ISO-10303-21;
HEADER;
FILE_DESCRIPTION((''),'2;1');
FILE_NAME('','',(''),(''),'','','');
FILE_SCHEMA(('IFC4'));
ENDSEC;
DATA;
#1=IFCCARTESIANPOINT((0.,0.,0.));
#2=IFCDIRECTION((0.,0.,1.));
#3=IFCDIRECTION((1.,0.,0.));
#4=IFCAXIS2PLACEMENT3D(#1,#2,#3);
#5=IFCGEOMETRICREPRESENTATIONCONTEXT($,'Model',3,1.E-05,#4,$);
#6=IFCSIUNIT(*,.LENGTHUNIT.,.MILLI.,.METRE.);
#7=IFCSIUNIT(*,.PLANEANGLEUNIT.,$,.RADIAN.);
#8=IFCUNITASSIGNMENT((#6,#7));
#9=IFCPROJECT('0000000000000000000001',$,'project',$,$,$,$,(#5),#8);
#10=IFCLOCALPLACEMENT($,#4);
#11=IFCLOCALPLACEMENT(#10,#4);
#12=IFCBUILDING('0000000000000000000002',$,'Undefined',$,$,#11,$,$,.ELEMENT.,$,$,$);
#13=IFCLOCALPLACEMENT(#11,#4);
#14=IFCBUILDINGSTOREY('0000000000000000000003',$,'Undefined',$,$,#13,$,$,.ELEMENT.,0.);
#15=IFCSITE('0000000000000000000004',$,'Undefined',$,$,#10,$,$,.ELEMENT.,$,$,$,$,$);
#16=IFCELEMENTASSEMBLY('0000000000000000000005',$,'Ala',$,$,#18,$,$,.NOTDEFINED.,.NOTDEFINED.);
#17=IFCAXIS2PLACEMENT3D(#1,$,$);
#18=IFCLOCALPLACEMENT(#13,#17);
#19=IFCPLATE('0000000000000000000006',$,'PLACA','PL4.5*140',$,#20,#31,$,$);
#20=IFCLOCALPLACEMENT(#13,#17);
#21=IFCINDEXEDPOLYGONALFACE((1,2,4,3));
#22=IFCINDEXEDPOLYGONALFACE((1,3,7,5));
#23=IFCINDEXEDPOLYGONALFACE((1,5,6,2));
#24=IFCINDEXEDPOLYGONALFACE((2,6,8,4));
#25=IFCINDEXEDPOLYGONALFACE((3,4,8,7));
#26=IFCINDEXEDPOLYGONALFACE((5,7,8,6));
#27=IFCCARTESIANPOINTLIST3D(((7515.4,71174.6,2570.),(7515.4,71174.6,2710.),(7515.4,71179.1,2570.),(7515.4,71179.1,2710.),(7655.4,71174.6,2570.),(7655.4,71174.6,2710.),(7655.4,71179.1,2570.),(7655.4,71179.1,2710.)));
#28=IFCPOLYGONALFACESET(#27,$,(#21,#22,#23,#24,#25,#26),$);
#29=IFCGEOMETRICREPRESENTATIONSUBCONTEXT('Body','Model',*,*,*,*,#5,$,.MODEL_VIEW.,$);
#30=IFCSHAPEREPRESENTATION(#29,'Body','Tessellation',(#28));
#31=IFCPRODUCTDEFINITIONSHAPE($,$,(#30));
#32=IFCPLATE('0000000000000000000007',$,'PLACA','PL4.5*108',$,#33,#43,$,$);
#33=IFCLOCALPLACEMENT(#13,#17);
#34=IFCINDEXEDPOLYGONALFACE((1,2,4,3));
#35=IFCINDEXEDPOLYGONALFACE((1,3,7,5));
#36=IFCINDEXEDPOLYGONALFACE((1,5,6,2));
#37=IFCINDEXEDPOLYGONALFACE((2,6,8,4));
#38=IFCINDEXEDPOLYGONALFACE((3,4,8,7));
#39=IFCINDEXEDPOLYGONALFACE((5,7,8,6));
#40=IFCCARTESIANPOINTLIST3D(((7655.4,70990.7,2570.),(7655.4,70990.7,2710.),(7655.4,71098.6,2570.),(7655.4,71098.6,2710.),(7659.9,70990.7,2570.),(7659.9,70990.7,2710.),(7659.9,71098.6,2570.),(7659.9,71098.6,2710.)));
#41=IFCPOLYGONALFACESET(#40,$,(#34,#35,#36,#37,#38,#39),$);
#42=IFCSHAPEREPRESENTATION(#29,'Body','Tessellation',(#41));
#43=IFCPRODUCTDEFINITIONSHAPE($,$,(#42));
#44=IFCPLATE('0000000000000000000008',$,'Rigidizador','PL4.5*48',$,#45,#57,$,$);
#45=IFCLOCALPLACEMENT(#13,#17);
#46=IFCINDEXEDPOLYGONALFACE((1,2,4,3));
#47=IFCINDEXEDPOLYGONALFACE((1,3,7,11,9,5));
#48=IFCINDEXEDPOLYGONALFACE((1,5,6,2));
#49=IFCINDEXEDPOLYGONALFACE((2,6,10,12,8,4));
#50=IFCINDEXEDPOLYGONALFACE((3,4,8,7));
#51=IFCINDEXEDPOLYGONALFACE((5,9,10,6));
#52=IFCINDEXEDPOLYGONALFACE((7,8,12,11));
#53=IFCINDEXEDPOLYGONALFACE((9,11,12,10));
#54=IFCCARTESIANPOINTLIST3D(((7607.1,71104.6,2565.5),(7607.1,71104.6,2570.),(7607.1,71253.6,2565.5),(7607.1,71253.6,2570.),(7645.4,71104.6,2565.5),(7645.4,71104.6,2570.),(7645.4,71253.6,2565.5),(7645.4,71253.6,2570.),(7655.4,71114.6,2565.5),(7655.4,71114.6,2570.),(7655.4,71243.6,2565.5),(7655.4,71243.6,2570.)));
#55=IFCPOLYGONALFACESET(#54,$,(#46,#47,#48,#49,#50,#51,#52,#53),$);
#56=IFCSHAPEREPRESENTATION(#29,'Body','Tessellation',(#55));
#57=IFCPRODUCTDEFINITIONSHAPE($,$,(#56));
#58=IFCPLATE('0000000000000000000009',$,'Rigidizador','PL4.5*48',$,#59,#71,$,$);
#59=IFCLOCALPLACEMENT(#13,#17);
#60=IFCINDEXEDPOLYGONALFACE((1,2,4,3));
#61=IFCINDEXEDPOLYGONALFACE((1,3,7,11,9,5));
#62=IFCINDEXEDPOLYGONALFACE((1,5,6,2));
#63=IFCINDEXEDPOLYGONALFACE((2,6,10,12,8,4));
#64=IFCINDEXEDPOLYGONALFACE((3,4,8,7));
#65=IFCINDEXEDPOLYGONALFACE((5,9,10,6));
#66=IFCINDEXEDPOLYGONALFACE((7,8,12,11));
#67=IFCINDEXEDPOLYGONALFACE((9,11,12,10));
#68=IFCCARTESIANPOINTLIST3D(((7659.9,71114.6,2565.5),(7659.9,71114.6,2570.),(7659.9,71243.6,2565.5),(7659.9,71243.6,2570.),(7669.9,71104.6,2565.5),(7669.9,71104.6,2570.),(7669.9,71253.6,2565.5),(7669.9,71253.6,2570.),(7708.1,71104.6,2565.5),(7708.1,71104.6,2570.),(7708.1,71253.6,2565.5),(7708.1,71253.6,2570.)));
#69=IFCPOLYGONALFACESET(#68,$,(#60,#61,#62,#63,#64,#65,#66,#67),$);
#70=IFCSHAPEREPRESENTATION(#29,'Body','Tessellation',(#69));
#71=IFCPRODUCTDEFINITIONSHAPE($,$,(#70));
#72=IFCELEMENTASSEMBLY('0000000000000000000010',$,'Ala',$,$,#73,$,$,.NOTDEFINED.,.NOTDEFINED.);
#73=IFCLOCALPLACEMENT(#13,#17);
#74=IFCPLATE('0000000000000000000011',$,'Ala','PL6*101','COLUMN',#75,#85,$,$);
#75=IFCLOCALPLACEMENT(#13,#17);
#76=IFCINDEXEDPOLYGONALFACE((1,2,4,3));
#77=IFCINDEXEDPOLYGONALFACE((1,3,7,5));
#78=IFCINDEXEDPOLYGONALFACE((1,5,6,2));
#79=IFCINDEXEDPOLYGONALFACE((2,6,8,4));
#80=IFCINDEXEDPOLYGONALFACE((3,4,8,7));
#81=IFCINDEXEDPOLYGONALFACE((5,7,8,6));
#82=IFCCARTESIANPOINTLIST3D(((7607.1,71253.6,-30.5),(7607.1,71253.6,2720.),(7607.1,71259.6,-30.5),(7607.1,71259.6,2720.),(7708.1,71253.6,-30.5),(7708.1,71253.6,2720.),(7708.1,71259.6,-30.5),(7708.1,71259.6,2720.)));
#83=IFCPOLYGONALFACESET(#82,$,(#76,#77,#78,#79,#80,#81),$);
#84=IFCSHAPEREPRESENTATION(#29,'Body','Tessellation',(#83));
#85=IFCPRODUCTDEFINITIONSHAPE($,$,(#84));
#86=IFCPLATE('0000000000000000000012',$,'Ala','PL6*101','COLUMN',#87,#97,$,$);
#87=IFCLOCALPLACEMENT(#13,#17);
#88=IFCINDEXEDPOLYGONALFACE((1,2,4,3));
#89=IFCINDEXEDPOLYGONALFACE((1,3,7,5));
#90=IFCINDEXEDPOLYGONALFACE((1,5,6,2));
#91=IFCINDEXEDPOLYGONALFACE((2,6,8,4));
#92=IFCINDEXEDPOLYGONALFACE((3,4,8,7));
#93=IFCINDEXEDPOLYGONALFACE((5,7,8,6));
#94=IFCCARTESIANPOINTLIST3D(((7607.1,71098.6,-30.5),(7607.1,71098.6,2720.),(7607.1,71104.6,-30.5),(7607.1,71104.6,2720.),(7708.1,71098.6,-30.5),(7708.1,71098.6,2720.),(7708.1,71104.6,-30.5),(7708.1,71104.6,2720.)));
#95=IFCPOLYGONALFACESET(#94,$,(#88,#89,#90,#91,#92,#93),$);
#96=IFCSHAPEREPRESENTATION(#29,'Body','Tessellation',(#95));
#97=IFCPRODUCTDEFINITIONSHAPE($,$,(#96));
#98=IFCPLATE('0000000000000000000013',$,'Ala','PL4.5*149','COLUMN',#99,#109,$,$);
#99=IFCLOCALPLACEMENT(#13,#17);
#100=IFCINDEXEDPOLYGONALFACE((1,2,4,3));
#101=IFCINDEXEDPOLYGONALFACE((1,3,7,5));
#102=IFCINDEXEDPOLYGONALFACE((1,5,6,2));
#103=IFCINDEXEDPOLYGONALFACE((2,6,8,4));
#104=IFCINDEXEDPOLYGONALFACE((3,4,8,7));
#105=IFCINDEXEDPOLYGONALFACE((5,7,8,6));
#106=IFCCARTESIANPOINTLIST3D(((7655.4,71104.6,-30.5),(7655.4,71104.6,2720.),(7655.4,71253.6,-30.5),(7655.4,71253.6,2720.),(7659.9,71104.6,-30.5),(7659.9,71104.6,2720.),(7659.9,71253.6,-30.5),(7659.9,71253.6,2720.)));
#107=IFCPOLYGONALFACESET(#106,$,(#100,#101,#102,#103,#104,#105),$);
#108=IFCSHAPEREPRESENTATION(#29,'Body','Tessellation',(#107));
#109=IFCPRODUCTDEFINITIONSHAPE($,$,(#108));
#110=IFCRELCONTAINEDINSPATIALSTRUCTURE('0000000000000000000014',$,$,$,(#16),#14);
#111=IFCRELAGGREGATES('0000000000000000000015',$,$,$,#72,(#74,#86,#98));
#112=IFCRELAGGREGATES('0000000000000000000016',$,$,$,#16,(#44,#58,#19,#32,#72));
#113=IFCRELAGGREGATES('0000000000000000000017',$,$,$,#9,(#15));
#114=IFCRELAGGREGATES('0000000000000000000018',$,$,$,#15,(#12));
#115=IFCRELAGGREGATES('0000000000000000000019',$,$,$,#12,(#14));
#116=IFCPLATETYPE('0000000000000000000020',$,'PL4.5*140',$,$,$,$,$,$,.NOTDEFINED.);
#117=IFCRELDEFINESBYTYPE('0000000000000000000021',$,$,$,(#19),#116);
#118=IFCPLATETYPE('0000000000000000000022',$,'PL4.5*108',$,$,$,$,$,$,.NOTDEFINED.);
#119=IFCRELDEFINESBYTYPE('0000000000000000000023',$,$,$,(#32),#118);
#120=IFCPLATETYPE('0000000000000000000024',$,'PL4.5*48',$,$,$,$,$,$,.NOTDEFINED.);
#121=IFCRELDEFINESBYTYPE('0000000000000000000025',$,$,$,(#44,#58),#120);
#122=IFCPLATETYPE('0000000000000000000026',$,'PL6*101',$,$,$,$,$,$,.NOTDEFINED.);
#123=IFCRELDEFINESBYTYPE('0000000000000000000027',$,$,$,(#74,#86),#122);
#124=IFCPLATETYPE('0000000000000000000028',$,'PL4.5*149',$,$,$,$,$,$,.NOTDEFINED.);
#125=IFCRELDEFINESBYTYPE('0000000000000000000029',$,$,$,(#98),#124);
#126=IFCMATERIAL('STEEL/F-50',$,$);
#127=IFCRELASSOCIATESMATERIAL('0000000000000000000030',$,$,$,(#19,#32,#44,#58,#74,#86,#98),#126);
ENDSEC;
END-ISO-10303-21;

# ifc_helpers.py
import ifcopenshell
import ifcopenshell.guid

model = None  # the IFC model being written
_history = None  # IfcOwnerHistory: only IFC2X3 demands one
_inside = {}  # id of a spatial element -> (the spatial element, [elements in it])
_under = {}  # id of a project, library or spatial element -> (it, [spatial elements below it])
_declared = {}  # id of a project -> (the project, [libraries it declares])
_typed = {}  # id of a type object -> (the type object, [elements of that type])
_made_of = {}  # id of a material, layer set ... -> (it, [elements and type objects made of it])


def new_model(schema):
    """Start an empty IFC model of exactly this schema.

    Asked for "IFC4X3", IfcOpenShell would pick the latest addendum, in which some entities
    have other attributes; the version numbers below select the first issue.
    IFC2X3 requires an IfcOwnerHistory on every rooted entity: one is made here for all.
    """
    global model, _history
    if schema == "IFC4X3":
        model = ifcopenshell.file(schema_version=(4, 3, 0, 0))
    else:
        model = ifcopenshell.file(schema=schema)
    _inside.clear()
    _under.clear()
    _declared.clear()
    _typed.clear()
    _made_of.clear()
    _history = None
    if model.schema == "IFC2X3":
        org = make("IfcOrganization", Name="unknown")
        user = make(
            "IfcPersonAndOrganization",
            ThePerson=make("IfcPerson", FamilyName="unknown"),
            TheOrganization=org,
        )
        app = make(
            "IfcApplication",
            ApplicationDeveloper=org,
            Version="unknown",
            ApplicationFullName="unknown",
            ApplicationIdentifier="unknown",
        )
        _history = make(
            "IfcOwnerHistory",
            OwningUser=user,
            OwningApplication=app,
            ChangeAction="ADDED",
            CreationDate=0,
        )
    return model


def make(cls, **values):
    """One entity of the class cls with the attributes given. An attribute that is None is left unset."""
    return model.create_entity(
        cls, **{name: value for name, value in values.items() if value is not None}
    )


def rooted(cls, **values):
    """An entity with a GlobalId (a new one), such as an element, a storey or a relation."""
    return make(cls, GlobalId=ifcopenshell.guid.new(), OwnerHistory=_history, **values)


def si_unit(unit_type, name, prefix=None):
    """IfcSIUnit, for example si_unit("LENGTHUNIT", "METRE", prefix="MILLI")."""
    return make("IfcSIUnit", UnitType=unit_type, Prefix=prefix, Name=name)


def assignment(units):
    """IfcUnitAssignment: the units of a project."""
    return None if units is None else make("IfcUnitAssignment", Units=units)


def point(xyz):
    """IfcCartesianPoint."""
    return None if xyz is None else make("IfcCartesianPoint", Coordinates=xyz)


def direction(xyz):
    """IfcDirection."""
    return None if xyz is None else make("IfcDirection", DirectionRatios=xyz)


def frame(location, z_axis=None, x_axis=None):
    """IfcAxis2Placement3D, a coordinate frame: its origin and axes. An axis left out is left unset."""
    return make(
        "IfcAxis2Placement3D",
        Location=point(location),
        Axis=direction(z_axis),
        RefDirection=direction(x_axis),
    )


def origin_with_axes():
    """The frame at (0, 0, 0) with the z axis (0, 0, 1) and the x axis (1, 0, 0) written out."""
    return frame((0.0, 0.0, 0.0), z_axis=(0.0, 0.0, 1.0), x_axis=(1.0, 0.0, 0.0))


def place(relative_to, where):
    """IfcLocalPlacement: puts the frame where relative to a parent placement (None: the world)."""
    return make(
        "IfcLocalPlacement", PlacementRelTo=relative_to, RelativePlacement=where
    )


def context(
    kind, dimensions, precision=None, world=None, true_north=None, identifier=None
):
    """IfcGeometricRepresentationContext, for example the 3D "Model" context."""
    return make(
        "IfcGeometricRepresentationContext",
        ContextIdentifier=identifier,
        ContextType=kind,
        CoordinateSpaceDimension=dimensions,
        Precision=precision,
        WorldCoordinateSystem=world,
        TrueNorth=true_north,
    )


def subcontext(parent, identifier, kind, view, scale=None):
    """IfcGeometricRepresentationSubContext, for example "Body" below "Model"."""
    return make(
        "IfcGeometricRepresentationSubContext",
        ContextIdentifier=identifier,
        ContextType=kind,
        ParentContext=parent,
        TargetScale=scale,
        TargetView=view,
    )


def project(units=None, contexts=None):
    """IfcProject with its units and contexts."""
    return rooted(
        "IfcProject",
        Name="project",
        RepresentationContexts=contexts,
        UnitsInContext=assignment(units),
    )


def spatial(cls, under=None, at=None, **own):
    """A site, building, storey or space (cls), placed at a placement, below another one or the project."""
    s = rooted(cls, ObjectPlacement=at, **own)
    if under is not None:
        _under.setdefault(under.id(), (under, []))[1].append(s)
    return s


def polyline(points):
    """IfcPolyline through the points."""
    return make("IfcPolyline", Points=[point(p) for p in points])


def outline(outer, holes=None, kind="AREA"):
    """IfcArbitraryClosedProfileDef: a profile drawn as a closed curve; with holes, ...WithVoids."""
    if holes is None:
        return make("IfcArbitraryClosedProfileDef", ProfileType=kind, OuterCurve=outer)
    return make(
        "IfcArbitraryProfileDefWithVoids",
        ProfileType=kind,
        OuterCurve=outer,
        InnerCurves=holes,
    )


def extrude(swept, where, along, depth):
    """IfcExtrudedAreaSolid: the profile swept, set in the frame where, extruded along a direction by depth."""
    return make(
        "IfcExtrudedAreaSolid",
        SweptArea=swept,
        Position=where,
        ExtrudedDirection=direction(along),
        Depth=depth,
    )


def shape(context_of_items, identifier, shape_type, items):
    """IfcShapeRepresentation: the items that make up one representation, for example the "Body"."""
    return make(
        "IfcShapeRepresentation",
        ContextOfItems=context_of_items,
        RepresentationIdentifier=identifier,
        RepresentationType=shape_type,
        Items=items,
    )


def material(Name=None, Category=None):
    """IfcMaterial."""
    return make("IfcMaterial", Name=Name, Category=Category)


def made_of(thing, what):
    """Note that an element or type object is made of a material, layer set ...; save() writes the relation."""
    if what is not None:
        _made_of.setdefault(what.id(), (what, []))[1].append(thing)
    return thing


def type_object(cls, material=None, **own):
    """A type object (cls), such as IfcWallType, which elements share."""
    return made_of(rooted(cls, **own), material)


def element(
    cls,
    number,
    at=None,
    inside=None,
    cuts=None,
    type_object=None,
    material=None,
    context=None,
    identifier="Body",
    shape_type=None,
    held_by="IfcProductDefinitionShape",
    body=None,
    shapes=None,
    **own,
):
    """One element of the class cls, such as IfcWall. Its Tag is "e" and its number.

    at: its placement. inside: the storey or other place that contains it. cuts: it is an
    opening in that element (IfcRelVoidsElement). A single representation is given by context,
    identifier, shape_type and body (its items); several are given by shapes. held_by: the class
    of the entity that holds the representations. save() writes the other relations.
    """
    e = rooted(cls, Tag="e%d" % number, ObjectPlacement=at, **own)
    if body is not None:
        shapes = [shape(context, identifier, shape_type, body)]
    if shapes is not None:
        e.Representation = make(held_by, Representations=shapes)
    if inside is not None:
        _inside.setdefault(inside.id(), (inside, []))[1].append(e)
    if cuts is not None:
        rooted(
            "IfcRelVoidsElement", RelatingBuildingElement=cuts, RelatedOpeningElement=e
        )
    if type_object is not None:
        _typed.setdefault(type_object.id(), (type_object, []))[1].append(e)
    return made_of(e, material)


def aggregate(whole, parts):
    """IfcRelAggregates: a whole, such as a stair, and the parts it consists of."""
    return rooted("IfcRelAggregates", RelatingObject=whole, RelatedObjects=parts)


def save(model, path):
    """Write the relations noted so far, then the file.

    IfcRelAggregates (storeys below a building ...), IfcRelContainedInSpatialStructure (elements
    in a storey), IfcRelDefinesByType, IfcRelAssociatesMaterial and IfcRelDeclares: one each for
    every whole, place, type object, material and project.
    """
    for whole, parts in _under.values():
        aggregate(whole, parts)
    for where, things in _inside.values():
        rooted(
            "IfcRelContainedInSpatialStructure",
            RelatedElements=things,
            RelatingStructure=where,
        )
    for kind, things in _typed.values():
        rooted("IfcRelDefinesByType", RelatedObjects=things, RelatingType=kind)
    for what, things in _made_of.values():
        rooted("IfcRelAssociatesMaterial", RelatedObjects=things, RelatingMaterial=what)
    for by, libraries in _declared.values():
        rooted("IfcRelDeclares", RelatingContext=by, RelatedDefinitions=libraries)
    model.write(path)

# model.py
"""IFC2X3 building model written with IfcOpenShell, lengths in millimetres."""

from ifc_helpers import new_model, si_unit, frame, origin_with_axes, place, context, subcontext, project, spatial, polyline, outline, extrude, material, type_object, element, aggregate, save


model = new_model("IFC2X3")

# Units and contexts
model_context = context("Model", 3, precision=1e-05, world=origin_with_axes())
body_context = subcontext(model_context, "Body", "Model", "MODEL_VIEW")
ifc_project = project(units=[si_unit("LENGTHUNIT", "METRE", prefix="MILLI"), si_unit("PLANEANGLEUNIT", "RADIAN")], contexts=[model_context])

# Site, building, storey
site_placement = place(None, origin_with_axes())
site = spatial("IfcSite", under=ifc_project, at=site_placement, Name="Undefined", CompositionType="ELEMENT")
building_placement = place(site_placement, origin_with_axes())
building = spatial("IfcBuilding", under=site, at=building_placement, Name="Undefined", CompositionType="ELEMENT")
storey_placement = place(building_placement, origin_with_axes())
storey = spatial("IfcBuildingStorey", under=building, at=storey_placement, Name="Undefined", CompositionType="ELEMENT", Elevation=0.0)

# Element assembly
assembly_1_placement = place(storey_placement, origin_with_axes())
assembly_1 = element("IfcElementAssembly", 1, at=assembly_1_placement, inside=storey, Name="Ala", AssemblyPlace="NOTDEFINED", PredefinedType="NOTDEFINED")

# Plates
ifc_material_1 = material(Name="STEEL/F-50")
plate_type_1 = type_object("IfcPlateType", Name="PL4.5*140", PredefinedType="NOTDEFINED")
plate_1_placement = place(assembly_1_placement, frame((7655.4, 71176.8, 2570.0), z_axis=(0.0, -1.0, 0.0), x_axis=(0.0, 0.0, 1.0)))
plate_1 = element("IfcPlate", 2, at=plate_1_placement, type_object=plate_type_1, material=ifc_material_1, Name="PLACA", Description="PL4.5*140", context=body_context, shape_type="SweptSolid", body=[
    extrude(outline(polyline([(0.0, 0.0), (140.0, 0.0), (140.0, 140.0), (0.0, 140.0), (0.0, 0.0)])), frame((0.0, 0.0, -2.2), z_axis=(0.0, 0.0, 1.0), x_axis=(1.0, 0.0, 0.0)), (0.0, 0.0, 1.0), 4.5),
])
plate_type_2 = type_object("IfcPlateType", Name="PL4.5*108", PredefinedType="NOTDEFINED")
plate_2_placement = place(assembly_1_placement, frame((7657.6, 71098.6, 2570.0), z_axis=(1.0, 0.0, 0.0), x_axis=(0.0, 0.0, 1.0)))
plate_2 = element("IfcPlate", 3, at=plate_2_placement, type_object=plate_type_2, material=ifc_material_1, Name="PLACA", Description="PL4.5*108", context=body_context, shape_type="SweptSolid", body=[
    extrude(outline(polyline([(0.0, 0.0), (140.0, 0.0), (140.0, 107.9), (0.0, 107.9), (0.0, 0.0)])), frame((0.0, 0.0, -2.2), z_axis=(0.0, 0.0, 1.0), x_axis=(1.0, 0.0, 0.0)), (0.0, 0.0, 1.0), 4.5),
])
plate_type_3 = type_object("IfcPlateType", Name="PL4.5*48", PredefinedType="NOTDEFINED")
plate_3_placement = place(assembly_1_placement, frame((7655.4, 71104.6, 2567.7), z_axis=(0.0, 0.0, -1.0), x_axis=(-1.0, 0.0, 0.0)))
plate_3 = element("IfcPlate", 4, at=plate_3_placement, type_object=plate_type_3, material=ifc_material_1, Name="Rigidizador", Description="PL4.5*48", context=body_context, shape_type="SweptSolid", body=[
    extrude(outline(polyline([(0.0, 10.0), (10.0, 0.0), (48.3, 0.0), (48.3, 149.0), (10.0, 149.0), (0.0, 139.0), (0.0, 10.0)])), frame((0.0, 0.0, -2.2), z_axis=(0.0, 0.0, 1.0), x_axis=(1.0, 0.0, 0.0)), (0.0, 0.0, 1.0), 4.5),
])
plate_4_placement = place(assembly_1_placement, frame((7659.9, 71104.6, 2567.7), z_axis=(0.0, 0.0, 1.0), x_axis=(1.0, 0.0, 0.0)))
plate_4 = element("IfcPlate", 5, at=plate_4_placement, type_object=plate_type_3, material=ifc_material_1, Name="Rigidizador", Description="PL4.5*48", context=body_context, shape_type="SweptSolid", body=[
    extrude(outline(polyline([(0.0, 10.0), (10.0, 0.0), (48.3, 0.0), (48.3, 149.0), (10.0, 149.0), (0.0, 139.0), (0.0, 10.0)])), frame((0.0, 0.0, -2.2), z_axis=(0.0, 0.0, 1.0), x_axis=(1.0, 0.0, 0.0)), (0.0, 0.0, 1.0), 4.5),
])

# Element assembly, plates
assembly_2_placement = place(assembly_1_placement, origin_with_axes())
assembly_2 = element("IfcElementAssembly", 6, at=assembly_2_placement, Name="Ala", AssemblyPlace="NOTDEFINED", PredefinedType="NOTDEFINED")
plate_type_4 = type_object("IfcPlateType", Name="PL6*101", PredefinedType="NOTDEFINED")
plate_5_placement = place(assembly_2_placement, frame((7657.6, 71256.6, -30.5), z_axis=(0.0, 1.0, 0.0), x_axis=(0.0, 0.0, 1.0)))
plate_5 = element("IfcPlate", 7, at=plate_5_placement, type_object=plate_type_4, material=ifc_material_1, Name="Ala", Description="PL6*101", ObjectType="COLUMN", context=body_context, shape_type="SweptSolid", body=[
    extrude(outline(polyline([(0.0, -50.5), (0.0, 50.5), (2750.5, 50.5), (2750.5, -50.5), (0.0, -50.5)])), frame((0.0, 0.0, -3.0), z_axis=(0.0, 0.0, 1.0), x_axis=(1.0, 0.0, 0.0)), (0.0, 0.0, 1.0), 6.0),
])
plate_6_placement = place(assembly_2_placement, frame((7657.6, 71101.6, -30.5), z_axis=(0.0, -1.0, 0.0), x_axis=(0.0, 0.0, 1.0)))
plate_6 = element("IfcPlate", 8, at=plate_6_placement, type_object=plate_type_4, material=ifc_material_1, Name="Ala", Description="PL6*101", ObjectType="COLUMN", context=body_context, shape_type="SweptSolid", body=[
    extrude(outline(polyline([(0.0, -50.5), (0.0, 50.5), (2750.5, 50.5), (2750.5, -50.5), (0.0, -50.5)])), frame((0.0, 0.0, -3.0), z_axis=(0.0, 0.0, 1.0), x_axis=(1.0, 0.0, 0.0)), (0.0, 0.0, 1.0), 6.0),
])
plate_type_5 = type_object("IfcPlateType", Name="PL4.5*149", PredefinedType="NOTDEFINED")
plate_7_placement = place(assembly_2_placement, frame((7657.6, 71179.1, -30.5), z_axis=(1.0, 0.0, 0.0), x_axis=(0.0, 0.0, 1.0)))
plate_7 = element("IfcPlate", 9, at=plate_7_placement, type_object=plate_type_5, material=ifc_material_1, Name="Ala", Description="PL4.5*149", ObjectType="COLUMN", context=body_context, shape_type="SweptSolid", body=[
    extrude(outline(polyline([(0.0, -74.5), (0.0, 74.5), (2750.5, 74.5), (2750.5, -74.5), (0.0, -74.5)])), frame((0.0, 0.0, -2.2), z_axis=(0.0, 0.0, 1.0), x_axis=(1.0, 0.0, 0.0)), (0.0, 0.0, 1.0), 4.5),
])
aggregate(assembly_2, [plate_5, plate_6, plate_7])

aggregate(assembly_1, [plate_3, plate_4, plate_1, plate_2, assembly_2])

save(model, "model.ifc")
